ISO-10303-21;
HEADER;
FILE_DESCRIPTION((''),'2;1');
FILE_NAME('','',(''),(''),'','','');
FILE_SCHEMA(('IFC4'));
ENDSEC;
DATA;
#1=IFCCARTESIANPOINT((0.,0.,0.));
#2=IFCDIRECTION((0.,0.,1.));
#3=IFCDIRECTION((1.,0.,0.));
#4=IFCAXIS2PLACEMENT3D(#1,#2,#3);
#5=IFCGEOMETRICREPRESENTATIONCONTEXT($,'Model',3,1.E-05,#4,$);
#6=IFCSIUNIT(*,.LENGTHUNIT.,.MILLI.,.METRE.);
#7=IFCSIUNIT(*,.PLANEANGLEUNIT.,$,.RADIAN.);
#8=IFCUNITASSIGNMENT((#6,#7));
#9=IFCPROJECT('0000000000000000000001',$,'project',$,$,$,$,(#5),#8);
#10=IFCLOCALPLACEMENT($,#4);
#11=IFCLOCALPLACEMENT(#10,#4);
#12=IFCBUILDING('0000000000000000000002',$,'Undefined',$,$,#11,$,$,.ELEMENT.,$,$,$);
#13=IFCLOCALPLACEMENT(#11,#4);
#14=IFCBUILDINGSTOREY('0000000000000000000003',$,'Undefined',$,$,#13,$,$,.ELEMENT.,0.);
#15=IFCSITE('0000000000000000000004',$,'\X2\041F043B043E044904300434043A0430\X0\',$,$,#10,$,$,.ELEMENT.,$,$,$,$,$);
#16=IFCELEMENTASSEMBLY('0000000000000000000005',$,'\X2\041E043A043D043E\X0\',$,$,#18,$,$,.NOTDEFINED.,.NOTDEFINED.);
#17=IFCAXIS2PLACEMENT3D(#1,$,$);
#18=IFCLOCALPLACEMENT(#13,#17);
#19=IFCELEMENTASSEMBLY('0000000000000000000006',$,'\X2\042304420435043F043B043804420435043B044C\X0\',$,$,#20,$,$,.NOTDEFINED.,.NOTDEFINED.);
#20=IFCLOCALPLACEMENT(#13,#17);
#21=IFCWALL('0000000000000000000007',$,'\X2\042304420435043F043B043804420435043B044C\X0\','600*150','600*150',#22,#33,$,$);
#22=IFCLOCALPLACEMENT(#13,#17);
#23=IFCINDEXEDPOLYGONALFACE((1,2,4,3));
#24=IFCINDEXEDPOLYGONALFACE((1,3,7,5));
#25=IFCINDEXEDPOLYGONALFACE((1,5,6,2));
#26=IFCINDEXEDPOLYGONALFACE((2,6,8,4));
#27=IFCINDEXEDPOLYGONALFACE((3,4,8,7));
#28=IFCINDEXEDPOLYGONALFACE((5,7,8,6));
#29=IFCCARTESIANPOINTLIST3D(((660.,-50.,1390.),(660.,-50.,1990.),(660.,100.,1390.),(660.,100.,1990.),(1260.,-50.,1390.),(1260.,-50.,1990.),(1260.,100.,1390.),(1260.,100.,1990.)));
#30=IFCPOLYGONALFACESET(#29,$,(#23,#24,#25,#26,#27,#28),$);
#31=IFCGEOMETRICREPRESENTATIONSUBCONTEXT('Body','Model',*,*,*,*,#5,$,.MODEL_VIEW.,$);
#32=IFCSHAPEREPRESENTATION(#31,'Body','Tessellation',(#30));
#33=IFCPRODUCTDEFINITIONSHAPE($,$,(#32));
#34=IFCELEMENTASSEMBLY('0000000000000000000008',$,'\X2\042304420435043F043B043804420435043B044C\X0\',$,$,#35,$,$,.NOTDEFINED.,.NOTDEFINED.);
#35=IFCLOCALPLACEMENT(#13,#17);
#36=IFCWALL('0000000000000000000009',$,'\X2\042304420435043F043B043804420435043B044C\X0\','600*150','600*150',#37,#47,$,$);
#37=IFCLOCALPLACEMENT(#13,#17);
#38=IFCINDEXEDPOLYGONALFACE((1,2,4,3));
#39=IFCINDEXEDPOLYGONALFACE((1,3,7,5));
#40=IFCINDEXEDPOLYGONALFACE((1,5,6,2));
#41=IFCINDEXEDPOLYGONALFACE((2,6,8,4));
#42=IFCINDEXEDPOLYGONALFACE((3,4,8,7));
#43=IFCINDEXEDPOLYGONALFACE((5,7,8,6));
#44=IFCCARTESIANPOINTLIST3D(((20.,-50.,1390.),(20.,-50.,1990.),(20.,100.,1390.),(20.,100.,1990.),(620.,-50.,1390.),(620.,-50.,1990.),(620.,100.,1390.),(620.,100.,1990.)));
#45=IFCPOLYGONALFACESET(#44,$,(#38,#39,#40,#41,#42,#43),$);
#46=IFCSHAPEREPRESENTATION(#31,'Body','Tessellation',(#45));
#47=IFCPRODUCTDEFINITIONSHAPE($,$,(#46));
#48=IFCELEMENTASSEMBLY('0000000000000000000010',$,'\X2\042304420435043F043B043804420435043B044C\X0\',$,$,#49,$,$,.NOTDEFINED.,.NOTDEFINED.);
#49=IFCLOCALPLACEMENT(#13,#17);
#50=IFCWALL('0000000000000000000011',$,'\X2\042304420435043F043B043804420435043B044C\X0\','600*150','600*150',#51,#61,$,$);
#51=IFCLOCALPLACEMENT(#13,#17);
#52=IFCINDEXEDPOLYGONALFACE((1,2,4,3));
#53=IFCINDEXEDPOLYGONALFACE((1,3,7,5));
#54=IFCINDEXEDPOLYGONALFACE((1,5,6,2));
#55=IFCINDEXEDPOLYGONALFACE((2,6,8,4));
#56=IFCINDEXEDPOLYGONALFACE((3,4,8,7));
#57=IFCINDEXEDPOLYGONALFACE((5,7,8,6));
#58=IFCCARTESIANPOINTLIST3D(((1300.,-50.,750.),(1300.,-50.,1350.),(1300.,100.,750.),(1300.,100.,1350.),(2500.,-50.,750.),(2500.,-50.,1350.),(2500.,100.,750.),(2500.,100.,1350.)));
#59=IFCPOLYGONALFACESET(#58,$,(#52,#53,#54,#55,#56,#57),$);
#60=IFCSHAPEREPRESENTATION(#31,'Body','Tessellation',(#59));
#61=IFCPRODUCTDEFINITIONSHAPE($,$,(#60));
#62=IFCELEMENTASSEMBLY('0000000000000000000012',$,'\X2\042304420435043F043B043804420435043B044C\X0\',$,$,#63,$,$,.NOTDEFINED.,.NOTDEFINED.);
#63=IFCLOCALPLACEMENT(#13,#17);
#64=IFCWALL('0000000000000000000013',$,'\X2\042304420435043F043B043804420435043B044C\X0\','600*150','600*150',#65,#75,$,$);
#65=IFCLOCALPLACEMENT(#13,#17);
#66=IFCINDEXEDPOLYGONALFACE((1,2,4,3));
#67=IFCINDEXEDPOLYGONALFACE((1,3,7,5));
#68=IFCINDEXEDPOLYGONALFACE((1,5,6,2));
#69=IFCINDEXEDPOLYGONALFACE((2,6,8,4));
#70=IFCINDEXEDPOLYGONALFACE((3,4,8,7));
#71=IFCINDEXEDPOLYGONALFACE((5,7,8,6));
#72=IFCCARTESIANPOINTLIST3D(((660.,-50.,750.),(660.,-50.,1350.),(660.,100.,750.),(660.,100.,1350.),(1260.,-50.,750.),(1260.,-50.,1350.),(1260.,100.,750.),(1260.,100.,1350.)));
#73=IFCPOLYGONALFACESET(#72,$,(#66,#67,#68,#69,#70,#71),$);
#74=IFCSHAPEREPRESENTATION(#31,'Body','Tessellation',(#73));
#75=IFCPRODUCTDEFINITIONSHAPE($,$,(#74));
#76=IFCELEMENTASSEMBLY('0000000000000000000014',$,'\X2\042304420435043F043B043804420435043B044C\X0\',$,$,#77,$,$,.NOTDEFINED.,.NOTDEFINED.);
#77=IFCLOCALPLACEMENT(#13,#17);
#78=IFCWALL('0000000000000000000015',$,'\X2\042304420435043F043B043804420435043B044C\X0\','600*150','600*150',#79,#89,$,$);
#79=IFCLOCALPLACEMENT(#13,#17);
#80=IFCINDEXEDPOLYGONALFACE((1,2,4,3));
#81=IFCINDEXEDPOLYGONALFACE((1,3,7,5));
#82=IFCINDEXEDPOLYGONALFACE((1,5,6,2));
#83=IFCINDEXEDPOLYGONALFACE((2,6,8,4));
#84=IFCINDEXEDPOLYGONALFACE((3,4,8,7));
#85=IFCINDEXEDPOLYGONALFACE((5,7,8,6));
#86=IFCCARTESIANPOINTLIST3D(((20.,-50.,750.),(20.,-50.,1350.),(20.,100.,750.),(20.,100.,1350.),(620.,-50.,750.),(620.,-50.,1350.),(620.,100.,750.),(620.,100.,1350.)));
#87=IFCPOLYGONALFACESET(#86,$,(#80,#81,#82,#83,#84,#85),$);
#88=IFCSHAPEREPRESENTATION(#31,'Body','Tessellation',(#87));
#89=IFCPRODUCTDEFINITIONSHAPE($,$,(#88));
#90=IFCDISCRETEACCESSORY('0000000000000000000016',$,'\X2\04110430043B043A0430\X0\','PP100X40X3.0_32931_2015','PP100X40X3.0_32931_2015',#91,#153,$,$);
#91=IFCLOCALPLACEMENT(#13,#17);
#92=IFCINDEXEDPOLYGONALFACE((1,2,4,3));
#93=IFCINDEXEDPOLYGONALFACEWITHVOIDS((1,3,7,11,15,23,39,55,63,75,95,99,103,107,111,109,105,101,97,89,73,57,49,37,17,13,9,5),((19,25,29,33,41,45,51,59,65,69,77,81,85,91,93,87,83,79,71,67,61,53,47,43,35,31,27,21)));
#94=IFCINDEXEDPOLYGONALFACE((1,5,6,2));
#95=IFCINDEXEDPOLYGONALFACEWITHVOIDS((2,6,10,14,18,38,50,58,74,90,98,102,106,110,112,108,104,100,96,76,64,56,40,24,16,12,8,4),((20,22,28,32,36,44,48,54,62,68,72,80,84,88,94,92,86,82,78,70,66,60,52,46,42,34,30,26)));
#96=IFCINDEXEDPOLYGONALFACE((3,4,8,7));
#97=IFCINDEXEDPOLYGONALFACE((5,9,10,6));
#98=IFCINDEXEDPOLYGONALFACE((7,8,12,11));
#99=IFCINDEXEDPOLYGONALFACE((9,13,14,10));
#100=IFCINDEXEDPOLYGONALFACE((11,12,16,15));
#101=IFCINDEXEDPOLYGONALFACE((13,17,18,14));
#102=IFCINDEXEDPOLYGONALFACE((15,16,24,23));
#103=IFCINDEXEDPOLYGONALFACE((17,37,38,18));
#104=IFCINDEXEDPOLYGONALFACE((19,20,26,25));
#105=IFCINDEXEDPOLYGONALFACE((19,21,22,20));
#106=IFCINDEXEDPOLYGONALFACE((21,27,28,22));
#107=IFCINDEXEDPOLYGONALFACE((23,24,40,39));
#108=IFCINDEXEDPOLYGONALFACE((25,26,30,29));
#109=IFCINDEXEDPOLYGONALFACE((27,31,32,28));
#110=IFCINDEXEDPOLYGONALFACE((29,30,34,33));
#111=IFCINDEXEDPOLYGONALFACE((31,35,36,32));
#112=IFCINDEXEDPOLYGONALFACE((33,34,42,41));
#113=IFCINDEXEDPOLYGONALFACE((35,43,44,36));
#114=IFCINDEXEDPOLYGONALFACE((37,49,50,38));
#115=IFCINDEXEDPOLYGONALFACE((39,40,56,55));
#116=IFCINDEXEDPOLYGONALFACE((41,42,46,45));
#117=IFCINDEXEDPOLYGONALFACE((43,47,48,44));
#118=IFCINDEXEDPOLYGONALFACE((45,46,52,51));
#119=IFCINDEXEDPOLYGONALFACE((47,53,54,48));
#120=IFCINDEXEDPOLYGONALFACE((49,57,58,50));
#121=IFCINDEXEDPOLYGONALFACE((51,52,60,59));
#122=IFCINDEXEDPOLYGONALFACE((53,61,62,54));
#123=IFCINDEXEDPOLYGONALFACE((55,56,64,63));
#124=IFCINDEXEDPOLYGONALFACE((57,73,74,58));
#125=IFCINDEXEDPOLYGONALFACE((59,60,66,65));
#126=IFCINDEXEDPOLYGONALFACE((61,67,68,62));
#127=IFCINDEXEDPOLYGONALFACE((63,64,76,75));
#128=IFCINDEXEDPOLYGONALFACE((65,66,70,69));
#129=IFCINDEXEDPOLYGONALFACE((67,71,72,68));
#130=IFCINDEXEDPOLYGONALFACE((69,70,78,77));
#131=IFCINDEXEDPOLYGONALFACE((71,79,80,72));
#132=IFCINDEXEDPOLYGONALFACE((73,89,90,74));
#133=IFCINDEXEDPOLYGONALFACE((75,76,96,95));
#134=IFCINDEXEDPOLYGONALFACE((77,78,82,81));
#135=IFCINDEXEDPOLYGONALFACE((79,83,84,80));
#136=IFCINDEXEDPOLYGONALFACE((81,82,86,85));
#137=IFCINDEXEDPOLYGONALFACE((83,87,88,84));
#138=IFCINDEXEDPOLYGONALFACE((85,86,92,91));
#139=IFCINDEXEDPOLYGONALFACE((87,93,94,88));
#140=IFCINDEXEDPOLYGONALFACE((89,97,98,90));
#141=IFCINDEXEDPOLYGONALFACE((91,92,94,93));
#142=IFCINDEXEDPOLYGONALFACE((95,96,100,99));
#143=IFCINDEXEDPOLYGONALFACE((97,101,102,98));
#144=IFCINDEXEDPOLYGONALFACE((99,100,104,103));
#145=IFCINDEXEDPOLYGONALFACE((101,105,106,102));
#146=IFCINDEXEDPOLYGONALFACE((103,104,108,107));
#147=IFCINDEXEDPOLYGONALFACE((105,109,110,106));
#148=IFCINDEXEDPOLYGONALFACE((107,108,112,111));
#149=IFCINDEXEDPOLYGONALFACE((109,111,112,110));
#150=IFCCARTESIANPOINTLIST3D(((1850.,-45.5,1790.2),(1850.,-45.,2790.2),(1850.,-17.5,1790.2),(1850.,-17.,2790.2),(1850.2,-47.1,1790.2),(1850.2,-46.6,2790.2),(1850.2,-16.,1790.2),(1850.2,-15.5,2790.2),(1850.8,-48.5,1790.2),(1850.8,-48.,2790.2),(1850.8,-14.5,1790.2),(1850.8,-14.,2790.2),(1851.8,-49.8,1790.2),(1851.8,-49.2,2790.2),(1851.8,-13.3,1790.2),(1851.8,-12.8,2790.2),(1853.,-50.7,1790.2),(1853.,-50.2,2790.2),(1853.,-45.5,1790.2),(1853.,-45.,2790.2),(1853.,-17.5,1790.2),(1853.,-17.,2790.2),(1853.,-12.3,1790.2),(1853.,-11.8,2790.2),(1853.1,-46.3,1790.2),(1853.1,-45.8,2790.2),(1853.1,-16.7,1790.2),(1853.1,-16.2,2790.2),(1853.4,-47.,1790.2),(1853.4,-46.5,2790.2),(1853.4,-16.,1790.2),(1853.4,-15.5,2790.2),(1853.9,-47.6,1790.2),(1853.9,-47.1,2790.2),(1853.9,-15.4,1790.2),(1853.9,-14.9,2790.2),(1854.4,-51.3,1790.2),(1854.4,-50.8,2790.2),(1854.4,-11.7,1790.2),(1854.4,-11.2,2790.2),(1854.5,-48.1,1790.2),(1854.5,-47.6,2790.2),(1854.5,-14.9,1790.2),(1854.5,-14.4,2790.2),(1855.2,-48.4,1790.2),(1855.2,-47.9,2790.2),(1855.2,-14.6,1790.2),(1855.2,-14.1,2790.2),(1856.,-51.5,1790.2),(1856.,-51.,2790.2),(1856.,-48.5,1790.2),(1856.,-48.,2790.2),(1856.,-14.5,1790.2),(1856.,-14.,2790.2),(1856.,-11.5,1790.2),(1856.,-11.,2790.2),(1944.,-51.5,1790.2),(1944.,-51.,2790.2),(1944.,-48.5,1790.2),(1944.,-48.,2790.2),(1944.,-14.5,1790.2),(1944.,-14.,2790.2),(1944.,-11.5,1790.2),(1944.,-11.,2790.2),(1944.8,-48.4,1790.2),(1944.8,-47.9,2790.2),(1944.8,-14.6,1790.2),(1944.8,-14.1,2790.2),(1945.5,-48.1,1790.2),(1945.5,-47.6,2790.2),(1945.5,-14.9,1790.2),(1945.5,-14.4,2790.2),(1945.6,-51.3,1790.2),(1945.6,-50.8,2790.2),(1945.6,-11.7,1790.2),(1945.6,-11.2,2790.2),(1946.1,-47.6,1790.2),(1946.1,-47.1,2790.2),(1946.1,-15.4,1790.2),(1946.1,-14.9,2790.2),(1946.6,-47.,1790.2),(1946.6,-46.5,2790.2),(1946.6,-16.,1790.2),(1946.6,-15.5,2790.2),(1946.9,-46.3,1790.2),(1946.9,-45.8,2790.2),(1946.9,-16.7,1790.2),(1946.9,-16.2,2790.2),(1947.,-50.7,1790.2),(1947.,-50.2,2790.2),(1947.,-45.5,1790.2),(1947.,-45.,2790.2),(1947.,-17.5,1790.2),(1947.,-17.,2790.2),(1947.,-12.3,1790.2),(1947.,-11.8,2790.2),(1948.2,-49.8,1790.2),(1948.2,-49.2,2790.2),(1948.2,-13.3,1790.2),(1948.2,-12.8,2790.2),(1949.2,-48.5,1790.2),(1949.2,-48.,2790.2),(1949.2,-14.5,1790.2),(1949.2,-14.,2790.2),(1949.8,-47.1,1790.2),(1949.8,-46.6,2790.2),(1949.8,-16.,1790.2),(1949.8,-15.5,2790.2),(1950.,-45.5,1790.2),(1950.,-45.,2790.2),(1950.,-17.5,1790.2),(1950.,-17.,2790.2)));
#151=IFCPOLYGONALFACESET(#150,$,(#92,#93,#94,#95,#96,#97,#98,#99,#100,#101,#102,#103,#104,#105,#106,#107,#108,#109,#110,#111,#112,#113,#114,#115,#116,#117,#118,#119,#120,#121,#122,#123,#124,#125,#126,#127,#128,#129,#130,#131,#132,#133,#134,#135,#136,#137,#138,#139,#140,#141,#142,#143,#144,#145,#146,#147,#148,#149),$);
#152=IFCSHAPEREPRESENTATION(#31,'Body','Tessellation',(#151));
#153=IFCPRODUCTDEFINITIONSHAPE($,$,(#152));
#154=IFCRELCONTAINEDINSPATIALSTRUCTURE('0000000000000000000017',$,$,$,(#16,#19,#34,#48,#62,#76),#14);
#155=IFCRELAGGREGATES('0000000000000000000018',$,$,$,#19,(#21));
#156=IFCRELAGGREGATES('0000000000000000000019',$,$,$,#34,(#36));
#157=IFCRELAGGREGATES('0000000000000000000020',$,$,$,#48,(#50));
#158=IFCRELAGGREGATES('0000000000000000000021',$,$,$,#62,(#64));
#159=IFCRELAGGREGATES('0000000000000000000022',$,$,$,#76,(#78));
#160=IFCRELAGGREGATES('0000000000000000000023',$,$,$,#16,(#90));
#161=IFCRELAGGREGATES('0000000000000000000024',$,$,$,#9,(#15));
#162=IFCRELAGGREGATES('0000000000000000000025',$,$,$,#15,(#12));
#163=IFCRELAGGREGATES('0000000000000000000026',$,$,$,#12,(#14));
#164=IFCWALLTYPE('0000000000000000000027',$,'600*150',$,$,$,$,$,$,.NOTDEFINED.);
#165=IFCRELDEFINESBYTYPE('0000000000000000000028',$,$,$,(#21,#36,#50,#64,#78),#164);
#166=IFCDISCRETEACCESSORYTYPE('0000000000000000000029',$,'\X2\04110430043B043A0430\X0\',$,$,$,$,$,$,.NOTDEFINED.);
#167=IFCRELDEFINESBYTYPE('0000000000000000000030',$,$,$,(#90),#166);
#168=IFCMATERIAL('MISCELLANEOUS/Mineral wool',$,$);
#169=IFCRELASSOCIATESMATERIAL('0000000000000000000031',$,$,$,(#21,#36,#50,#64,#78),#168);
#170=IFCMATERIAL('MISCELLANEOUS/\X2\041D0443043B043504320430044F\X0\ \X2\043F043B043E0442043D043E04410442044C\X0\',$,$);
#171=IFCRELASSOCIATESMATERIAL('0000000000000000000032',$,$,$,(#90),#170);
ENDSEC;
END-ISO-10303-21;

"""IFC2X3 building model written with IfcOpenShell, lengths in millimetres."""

from ifc_helpers import new_model, si_unit, frame, frame_2d, origin_with_axes, origin_2d_with_axis, place, context, subcontext, project, spatial, rectangle, hollow_rectangle, extrude, material, type_object, element, aggregate, save


model = new_model("IFC2X3")

# Units and contexts
model_context = context("Model", 3, precision=1e-05, world=origin_with_axes())
body_context = subcontext(model_context, "Body", "Model", "MODEL_VIEW")
ifc_project = project(units=[si_unit("LENGTHUNIT", "METRE", prefix="MILLI"), si_unit("PLANEANGLEUNIT", "RADIAN")], contexts=[model_context])

# Site, building, storey
site_placement = place(None, origin_with_axes())
site = spatial("IfcSite", under=ifc_project, at=site_placement, Name="Площадка", CompositionType="ELEMENT")
building_placement = place(site_placement, origin_with_axes())
building = spatial("IfcBuilding", under=site, at=building_placement, Name="Undefined", CompositionType="ELEMENT")
storey_placement = place(building_placement, origin_with_axes())
storey = spatial("IfcBuildingStorey", under=building, at=storey_placement, Name="Undefined", CompositionType="ELEMENT", Elevation=0.0)

# Element assembly
assembly_1_placement = place(storey_placement, origin_with_axes())
assembly_1 = element("IfcElementAssembly", 1, at=assembly_1_placement, inside=storey, Name="Окно", AssemblyPlace="NOTDEFINED", PredefinedType="NOTDEFINED")
ifc_material_1 = material(Name="MISCELLANEOUS/Нулевая плотность")

# Element assemblies, walls
ifc_material_2 = material(Name="MISCELLANEOUS/Mineral wool")
assembly_2_placement = place(storey_placement, origin_with_axes())
assembly_2 = element("IfcElementAssembly", 2, at=assembly_2_placement, inside=storey, Name="Утеплитель", AssemblyPlace="NOTDEFINED", PredefinedType="NOTDEFINED")
wall_type_1 = type_object("IfcWallType", Name="600*150", PredefinedType="NOTDEFINED")
wall_1_placement = place(assembly_2_placement, frame((660.0, 25.0, 1390.0), z_axis=(0.0, 0.0, 1.0), x_axis=(1.0, 0.0, 0.0)))
wall_1 = element("IfcWall", 3, at=wall_1_placement, type_object=wall_type_1, material=ifc_material_2, Name="Утеплитель", Description="600*150", ObjectType="600*150", context=body_context, shape_type="SweptSolid", body=[
    extrude(rectangle(XDim=600.0, YDim=150.0, at=frame_2d((0.0, 300.0), x_axis=(0.0, -1.0))), frame((0.0, 0.0, 0.0), z_axis=(0.0, 0.0, 1.0), x_axis=(0.0, -1.0, 0.0)), (0.0, 0.0, 1.0), 600.0),
])
aggregate(assembly_2, [wall_1])
assembly_3_placement = place(storey_placement, origin_with_axes())
assembly_3 = element("IfcElementAssembly", 4, at=assembly_3_placement, inside=storey, Name="Утеплитель", AssemblyPlace="NOTDEFINED", PredefinedType="NOTDEFINED")
wall_2_placement = place(assembly_3_placement, frame((20.0, 25.0, 1390.0), z_axis=(0.0, 0.0, 1.0), x_axis=(1.0, 0.0, 0.0)))
wall_2 = element("IfcWall", 5, at=wall_2_placement, type_object=wall_type_1, material=ifc_material_2, Name="Утеплитель", Description="600*150", ObjectType="600*150", context=body_context, shape_type="SweptSolid", body=[
    extrude(rectangle(XDim=600.0, YDim=150.0, at=frame_2d((0.0, 300.0), x_axis=(0.0, -1.0))), frame((0.0, 0.0, 0.0), z_axis=(0.0, 0.0, 1.0), x_axis=(0.0, -1.0, 0.0)), (0.0, 0.0, 1.0), 600.0),
])
aggregate(assembly_3, [wall_2])
assembly_4_placement = place(storey_placement, origin_with_axes())
assembly_4 = element("IfcElementAssembly", 6, at=assembly_4_placement, inside=storey, Name="Утеплитель", AssemblyPlace="NOTDEFINED", PredefinedType="NOTDEFINED")
wall_3_placement = place(assembly_4_placement, frame((1300.0, 25.0, 750.0), z_axis=(0.0, 0.0, 1.0), x_axis=(1.0, 0.0, 0.0)))
wall_3 = element("IfcWall", 7, at=wall_3_placement, type_object=wall_type_1, material=ifc_material_2, Name="Утеплитель", Description="600*150", ObjectType="600*150", context=body_context, shape_type="SweptSolid", body=[
    extrude(rectangle(XDim=1200.0, YDim=150.0, at=frame_2d((0.0, 600.0), x_axis=(0.0, -1.0))), frame((0.0, 0.0, 0.0), z_axis=(0.0, 0.0, 1.0), x_axis=(0.0, -1.0, 0.0)), (0.0, 0.0, 1.0), 600.0),
])
aggregate(assembly_4, [wall_3])
assembly_5_placement = place(storey_placement, origin_with_axes())
assembly_5 = element("IfcElementAssembly", 8, at=assembly_5_placement, inside=storey, Name="Утеплитель", AssemblyPlace="NOTDEFINED", PredefinedType="NOTDEFINED")
wall_4_placement = place(assembly_5_placement, frame((660.0, 25.0, 750.0), z_axis=(0.0, 0.0, 1.0), x_axis=(1.0, 0.0, 0.0)))
wall_4 = element("IfcWall", 9, at=wall_4_placement, type_object=wall_type_1, material=ifc_material_2, Name="Утеплитель", Description="600*150", ObjectType="600*150", context=body_context, shape_type="SweptSolid", body=[
    extrude(rectangle(XDim=600.0, YDim=150.0, at=frame_2d((0.0, 300.0), x_axis=(0.0, -1.0))), frame((0.0, 0.0, 0.0), z_axis=(0.0, 0.0, 1.0), x_axis=(0.0, -1.0, 0.0)), (0.0, 0.0, 1.0), 600.0),
])
aggregate(assembly_5, [wall_4])
assembly_6_placement = place(storey_placement, origin_with_axes())
assembly_6 = element("IfcElementAssembly", 10, at=assembly_6_placement, inside=storey, Name="Утеплитель", AssemblyPlace="NOTDEFINED", PredefinedType="NOTDEFINED")
wall_5_placement = place(assembly_6_placement, frame((20.0, 25.0, 750.0), z_axis=(0.0, 0.0, 1.0), x_axis=(1.0, 0.0, 0.0)))
wall_5 = element("IfcWall", 11, at=wall_5_placement, type_object=wall_type_1, material=ifc_material_2, Name="Утеплитель", Description="600*150", ObjectType="600*150", context=body_context, shape_type="SweptSolid", body=[
    extrude(rectangle(XDim=600.0, YDim=150.0, at=frame_2d((0.0, 300.0), x_axis=(0.0, -1.0))), frame((0.0, 0.0, 0.0), z_axis=(0.0, 0.0, 1.0), x_axis=(0.0, -1.0, 0.0)), (0.0, 0.0, 1.0), 600.0),
])
aggregate(assembly_6, [wall_5])

# Discrete accessory
discrete_accessory_type = type_object("IfcDiscreteAccessoryType", Name="Балка")
discrete_accessory_1_placement = place(assembly_1_placement, frame((1900.0, -31.5, 1790.2), z_axis=(0.0, 0.000503, 1.0), x_axis=(-1.0, 0.0, 0.0)))
discrete_accessory_1 = element("IfcDiscreteAccessory", 12, at=discrete_accessory_1_placement, type_object=discrete_accessory_type, material=ifc_material_1, Name="Балка", Description="PP100X40X3.0_32931_2015", ObjectType="PP100X40X3.0_32931_2015", context=body_context, shape_type="SweptSolid", body=[
    extrude(hollow_rectangle(XDim=40.0, YDim=100.0, WallThickness=3.0, InnerFilletRadius=3.0, OuterFilletRadius=6.0, at=origin_2d_with_axis()), frame((0.0, 0.0, 1000.0), z_axis=(0.0, 0.0, -1.0), x_axis=(0.0, 1.0, 0.0)), (0.0, 0.0, 1.0), 1000.0),
])
aggregate(assembly_1, [discrete_accessory_1])

save(model, "model.ifc")
